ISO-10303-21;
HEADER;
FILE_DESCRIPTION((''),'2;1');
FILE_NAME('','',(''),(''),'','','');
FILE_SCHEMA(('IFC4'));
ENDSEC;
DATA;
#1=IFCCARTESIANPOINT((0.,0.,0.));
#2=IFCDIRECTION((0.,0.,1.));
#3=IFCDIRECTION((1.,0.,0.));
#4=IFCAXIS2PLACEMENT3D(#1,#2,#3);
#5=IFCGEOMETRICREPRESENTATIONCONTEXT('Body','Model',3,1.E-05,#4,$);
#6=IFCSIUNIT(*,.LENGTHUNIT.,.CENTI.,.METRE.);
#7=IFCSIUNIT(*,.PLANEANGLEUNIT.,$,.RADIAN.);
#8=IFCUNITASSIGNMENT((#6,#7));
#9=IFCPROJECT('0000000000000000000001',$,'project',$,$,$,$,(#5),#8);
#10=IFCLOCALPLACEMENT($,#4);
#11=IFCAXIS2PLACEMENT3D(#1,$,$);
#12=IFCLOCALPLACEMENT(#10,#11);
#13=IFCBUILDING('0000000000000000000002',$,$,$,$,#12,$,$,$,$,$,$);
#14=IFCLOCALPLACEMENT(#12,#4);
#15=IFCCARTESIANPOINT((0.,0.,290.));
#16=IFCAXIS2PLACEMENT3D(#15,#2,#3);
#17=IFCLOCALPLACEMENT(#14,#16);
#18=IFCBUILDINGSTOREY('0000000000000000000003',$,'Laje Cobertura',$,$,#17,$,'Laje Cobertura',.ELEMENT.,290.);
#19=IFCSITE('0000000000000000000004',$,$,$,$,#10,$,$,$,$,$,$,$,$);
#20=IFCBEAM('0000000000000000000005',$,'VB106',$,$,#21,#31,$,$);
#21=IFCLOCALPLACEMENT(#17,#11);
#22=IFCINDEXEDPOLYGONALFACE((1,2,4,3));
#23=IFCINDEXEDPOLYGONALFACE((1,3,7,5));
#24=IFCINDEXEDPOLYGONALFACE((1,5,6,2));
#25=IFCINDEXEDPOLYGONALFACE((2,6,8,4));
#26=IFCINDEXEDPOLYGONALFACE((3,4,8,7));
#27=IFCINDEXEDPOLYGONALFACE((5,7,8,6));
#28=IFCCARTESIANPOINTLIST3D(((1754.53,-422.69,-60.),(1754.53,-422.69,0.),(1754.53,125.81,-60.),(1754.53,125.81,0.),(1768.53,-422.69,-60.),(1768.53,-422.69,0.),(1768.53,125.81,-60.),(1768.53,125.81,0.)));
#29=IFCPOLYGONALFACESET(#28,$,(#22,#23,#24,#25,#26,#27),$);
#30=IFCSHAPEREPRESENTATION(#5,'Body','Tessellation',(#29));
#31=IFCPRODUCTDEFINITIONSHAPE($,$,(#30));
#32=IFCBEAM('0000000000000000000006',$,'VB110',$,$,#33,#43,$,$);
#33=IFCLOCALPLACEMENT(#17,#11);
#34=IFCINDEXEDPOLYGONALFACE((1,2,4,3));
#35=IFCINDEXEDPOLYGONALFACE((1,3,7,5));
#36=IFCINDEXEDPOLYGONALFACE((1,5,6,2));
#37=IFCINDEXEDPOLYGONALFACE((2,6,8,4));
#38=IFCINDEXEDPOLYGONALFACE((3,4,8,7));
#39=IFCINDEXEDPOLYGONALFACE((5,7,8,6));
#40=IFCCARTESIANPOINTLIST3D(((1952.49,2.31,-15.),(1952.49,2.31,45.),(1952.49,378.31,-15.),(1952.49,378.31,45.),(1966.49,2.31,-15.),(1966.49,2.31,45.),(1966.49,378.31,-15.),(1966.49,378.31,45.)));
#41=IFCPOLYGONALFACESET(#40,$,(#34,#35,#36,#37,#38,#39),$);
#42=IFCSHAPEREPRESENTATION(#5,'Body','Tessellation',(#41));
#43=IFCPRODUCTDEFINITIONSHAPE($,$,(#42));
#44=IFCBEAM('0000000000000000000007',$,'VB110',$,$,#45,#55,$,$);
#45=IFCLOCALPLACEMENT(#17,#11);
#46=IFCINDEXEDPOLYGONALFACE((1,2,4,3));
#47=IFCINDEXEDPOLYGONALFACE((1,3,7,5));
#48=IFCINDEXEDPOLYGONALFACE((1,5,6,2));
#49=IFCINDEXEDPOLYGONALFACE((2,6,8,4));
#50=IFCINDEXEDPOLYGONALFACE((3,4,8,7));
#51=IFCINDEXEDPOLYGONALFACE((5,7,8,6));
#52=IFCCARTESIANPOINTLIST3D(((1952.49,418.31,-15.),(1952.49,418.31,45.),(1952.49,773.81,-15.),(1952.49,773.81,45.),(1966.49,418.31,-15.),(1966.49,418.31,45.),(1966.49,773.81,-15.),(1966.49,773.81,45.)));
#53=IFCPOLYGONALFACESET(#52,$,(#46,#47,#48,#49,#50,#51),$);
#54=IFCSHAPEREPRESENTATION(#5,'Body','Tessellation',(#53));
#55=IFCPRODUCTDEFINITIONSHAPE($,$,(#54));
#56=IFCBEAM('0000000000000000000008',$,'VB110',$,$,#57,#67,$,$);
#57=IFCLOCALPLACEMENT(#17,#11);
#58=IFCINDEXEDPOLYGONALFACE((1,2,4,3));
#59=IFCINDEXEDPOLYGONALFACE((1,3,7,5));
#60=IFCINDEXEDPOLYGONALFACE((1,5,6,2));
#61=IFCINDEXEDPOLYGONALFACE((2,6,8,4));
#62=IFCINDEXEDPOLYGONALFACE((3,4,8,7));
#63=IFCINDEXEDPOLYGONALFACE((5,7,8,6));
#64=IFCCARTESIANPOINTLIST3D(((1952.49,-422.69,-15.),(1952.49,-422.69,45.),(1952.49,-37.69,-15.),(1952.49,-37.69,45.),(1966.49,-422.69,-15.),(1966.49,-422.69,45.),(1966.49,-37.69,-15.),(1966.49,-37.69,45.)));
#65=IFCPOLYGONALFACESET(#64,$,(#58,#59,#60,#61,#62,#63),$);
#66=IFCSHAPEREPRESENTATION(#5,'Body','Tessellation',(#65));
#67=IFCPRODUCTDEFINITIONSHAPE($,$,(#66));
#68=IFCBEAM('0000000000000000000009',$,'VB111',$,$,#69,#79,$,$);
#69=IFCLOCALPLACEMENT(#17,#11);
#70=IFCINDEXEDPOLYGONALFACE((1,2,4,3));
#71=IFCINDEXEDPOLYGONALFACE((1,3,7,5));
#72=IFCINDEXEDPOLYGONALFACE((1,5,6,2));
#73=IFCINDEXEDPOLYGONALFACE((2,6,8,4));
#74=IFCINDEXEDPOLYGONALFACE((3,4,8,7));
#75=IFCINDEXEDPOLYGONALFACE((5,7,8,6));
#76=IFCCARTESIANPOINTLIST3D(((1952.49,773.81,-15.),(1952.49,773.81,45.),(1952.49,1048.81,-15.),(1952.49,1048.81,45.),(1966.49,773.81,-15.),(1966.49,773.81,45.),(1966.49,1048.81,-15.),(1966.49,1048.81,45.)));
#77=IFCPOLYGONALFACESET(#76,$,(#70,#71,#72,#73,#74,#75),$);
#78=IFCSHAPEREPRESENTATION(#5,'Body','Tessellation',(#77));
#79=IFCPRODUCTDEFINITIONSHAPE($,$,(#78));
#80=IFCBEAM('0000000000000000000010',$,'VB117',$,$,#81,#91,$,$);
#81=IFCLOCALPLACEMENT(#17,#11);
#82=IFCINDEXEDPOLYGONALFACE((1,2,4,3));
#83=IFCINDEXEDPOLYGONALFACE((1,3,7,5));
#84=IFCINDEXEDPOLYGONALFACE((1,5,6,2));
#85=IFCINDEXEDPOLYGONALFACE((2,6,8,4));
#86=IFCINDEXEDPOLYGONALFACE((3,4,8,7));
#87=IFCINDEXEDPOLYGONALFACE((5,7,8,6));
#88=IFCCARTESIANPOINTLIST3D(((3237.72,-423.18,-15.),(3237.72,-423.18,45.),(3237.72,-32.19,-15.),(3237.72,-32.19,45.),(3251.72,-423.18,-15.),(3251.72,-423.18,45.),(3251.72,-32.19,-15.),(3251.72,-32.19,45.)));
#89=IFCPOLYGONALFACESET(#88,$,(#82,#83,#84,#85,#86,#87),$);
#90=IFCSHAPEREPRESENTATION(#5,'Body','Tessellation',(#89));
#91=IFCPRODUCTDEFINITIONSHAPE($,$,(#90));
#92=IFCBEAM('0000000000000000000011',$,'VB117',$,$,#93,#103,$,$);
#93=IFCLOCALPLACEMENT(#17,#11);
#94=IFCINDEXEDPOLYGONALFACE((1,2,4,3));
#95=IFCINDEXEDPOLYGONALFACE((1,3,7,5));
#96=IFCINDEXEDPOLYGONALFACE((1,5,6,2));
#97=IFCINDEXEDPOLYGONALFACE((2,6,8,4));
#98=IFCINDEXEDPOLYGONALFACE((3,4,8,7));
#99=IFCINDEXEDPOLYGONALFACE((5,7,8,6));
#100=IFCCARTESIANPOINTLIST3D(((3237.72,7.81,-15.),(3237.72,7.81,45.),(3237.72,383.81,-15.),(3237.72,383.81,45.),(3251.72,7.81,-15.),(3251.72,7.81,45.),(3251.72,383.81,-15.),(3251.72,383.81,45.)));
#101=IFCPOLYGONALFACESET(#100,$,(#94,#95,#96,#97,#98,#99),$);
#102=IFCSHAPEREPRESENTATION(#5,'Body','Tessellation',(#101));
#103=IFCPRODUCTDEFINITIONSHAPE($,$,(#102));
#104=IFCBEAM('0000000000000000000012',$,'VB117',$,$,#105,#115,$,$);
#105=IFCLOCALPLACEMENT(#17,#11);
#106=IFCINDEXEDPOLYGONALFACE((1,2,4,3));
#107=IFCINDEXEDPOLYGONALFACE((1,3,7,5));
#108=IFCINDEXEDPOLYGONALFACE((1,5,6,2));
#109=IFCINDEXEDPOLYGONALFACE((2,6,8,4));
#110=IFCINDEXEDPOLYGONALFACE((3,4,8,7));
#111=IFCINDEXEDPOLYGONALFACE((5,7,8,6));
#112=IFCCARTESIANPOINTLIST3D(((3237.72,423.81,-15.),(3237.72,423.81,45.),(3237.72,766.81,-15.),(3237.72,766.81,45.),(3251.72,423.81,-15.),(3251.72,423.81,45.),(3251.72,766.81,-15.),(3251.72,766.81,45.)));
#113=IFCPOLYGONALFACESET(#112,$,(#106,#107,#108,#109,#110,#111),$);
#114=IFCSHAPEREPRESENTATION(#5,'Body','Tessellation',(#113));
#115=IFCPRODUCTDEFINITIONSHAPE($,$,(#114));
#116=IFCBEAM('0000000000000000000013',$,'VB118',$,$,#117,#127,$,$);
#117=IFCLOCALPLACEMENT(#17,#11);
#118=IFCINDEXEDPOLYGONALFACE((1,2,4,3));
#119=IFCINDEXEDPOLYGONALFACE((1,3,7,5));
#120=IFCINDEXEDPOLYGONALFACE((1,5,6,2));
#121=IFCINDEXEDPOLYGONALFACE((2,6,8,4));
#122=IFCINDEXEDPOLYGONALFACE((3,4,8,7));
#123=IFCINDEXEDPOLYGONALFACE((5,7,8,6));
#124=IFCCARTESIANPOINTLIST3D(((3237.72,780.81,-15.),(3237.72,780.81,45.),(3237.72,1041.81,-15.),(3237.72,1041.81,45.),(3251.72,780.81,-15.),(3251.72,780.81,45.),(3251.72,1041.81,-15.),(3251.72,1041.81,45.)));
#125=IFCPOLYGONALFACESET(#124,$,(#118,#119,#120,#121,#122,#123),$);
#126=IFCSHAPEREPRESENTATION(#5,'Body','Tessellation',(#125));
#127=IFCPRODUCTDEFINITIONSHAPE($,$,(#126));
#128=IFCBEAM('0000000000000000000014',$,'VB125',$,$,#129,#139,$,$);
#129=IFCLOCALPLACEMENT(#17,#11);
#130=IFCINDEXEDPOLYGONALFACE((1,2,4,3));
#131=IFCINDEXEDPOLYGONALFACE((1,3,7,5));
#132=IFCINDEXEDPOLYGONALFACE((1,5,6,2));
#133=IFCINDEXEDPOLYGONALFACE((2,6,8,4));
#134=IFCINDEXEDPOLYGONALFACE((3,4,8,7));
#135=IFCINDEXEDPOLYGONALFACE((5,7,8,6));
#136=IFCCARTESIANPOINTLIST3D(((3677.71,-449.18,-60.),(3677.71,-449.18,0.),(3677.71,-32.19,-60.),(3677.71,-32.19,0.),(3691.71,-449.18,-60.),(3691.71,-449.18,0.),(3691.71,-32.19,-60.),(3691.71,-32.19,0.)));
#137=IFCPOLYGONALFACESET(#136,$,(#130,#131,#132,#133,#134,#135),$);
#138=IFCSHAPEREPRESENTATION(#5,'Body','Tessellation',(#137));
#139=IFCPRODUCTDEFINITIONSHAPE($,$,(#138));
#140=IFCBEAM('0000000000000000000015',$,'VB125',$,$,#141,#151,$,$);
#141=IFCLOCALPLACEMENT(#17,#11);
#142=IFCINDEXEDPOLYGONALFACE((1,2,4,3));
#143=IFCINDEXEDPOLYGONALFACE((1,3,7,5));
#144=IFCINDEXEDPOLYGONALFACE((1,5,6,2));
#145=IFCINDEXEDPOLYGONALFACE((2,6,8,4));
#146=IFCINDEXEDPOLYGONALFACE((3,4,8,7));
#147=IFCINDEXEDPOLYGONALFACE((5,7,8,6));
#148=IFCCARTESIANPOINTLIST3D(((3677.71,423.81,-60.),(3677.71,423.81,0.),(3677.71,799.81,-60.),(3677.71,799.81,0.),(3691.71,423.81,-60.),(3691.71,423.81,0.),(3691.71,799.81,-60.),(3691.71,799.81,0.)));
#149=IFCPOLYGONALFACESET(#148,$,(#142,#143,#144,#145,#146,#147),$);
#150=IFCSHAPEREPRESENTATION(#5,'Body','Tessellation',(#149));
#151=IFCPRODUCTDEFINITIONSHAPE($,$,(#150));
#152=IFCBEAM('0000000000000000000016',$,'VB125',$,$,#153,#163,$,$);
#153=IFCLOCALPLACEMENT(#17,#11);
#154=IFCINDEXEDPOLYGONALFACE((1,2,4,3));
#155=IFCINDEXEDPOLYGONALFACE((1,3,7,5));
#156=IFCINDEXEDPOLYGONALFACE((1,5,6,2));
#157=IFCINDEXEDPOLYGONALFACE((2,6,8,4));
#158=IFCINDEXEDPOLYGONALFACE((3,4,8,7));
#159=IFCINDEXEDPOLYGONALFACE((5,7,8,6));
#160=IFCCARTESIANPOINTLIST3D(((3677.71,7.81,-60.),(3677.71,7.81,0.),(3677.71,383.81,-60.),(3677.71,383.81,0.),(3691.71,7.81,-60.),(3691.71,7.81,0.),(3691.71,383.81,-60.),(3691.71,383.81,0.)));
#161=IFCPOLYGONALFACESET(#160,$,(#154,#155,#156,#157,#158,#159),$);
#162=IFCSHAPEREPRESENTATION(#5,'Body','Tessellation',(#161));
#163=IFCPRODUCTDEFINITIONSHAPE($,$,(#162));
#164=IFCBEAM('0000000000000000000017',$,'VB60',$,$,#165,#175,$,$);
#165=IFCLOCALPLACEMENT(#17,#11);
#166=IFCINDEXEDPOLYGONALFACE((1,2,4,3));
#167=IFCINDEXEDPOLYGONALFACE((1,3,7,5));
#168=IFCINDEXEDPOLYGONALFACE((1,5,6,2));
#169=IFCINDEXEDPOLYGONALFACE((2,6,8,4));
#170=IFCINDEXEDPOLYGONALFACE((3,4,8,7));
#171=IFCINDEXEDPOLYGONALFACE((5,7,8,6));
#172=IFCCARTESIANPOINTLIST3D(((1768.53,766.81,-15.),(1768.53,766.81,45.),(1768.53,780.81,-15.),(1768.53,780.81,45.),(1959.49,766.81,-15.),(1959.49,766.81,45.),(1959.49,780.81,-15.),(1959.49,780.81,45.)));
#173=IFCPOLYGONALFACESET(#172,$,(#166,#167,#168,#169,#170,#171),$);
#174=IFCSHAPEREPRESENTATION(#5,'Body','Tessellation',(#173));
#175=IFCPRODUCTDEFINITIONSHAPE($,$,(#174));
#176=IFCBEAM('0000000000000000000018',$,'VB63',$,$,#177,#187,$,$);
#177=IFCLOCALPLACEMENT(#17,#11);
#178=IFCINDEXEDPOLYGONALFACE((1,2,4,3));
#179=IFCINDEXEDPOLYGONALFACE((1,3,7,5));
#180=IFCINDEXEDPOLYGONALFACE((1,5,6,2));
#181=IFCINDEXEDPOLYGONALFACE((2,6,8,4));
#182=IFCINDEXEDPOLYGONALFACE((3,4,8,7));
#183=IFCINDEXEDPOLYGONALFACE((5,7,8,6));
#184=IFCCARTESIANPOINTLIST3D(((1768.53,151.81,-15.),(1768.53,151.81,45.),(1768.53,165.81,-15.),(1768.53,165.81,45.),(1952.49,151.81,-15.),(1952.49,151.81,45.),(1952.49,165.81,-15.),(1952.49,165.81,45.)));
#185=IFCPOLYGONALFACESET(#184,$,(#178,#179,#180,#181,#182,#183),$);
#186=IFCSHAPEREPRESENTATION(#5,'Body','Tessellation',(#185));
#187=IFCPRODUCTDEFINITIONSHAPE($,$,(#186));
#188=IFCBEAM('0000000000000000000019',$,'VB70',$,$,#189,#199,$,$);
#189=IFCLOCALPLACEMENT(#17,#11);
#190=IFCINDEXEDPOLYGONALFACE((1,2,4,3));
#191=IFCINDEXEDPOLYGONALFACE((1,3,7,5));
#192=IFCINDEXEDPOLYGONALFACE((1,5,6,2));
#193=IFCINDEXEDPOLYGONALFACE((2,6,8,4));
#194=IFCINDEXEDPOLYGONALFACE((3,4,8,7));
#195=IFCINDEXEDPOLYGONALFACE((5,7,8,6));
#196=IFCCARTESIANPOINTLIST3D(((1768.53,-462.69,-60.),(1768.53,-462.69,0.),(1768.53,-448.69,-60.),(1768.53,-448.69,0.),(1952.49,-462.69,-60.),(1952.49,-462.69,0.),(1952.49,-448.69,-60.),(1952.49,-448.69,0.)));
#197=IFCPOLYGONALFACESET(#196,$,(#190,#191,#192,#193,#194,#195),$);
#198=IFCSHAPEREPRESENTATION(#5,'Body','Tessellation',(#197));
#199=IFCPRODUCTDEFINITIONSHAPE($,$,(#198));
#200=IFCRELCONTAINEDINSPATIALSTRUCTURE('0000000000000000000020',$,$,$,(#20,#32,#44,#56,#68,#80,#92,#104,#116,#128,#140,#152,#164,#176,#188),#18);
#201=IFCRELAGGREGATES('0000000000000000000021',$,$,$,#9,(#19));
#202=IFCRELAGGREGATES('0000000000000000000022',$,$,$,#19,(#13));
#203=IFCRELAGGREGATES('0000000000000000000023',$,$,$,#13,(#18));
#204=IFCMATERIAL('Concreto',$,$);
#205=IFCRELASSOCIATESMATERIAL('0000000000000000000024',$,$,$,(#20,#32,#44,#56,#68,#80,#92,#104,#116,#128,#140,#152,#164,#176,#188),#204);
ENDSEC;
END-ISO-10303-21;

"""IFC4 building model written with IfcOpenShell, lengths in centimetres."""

from ifc_helpers import new_model, si_unit, frame, origin, origin_with_axes, origin_2d_with_axis, place, context, project, spatial, rectangle, extrude, material, element, save


model = new_model("IFC4")

# Units and contexts
model_context = context("Model", 3, precision=1e-05, world=origin_with_axes(), identifier="Body")
ifc_project = project(units=[si_unit("LENGTHUNIT", "METRE", prefix="CENTI"), si_unit("PLANEANGLEUNIT", "RADIAN")], contexts=[model_context])

# Site, building, storey
site_placement = place(None, origin_with_axes())
site = spatial("IfcSite", under=ifc_project, at=site_placement)
building_placement = place(site_placement, origin())
building = spatial("IfcBuilding", under=site, at=building_placement)
placement = place(building_placement, origin_with_axes())
storey_placement = place(placement, frame((0.0, 0.0, 290.0), z_axis=(0.0, 0.0, 1.0), x_axis=(1.0, 0.0, 0.0)))
storey = spatial("IfcBuildingStorey", under=building, at=storey_placement, Name="Laje Cobertura", LongName="Laje Cobertura", CompositionType="ELEMENT", Elevation=290.0)

# Shared definitions
ifc_material = material(Name="Concreto")

# Beams
beam_1_placement = place(storey_placement, frame((1761.53, -148.44, 0.0), z_axis=(0.0, 0.0, 1.0), x_axis=(1.0, 0.0, 0.0)))
element("IfcBeam", 1, at=beam_1_placement, inside=storey, material=ifc_material, Name="VB106", context=model_context, shape_type="SolidModel", body=[
    extrude(rectangle(XDim=14.0, YDim=60.0, at=origin_2d_with_axis()), frame((0.0, -274.25, -30.0), z_axis=(0.0, 1.0, 0.0), x_axis=(1.0, 0.0, 0.0)), (0.0, 0.0, 1.0), 548.5),
])
beam_2_placement = place(storey_placement, frame((1959.49, 190.31, 45.0), z_axis=(0.0, 0.0, 1.0), x_axis=(1.0, 0.0, 0.0)))
element("IfcBeam", 2, at=beam_2_placement, inside=storey, material=ifc_material, Name="VB110", context=model_context, shape_type="SolidModel", body=[
    extrude(rectangle(XDim=14.0, YDim=60.0, at=origin_2d_with_axis()), frame((0.0, -188.0, -30.0), z_axis=(0.0, 1.0, 0.0), x_axis=(1.0, 0.0, 0.0)), (0.0, 0.0, 1.0), 376.0),
])
beam_3_placement = place(storey_placement, frame((1959.49, 596.06, 45.0), z_axis=(0.0, 0.0, 1.0), x_axis=(1.0, 0.0, 0.0)))
element("IfcBeam", 3, at=beam_3_placement, inside=storey, material=ifc_material, Name="VB110", context=model_context, shape_type="SolidModel", body=[
    extrude(rectangle(XDim=14.0, YDim=60.0, at=origin_2d_with_axis()), frame((0.0, -177.75, -30.0), z_axis=(0.0, 1.0, 0.0), x_axis=(1.0, 0.0, 0.0)), (0.0, 0.0, 1.0), 355.5),
])
beam_4_placement = place(storey_placement, frame((1959.49, -230.19, 45.0), z_axis=(0.0, 0.0, 1.0), x_axis=(1.0, 0.0, 0.0)))
element("IfcBeam", 4, at=beam_4_placement, inside=storey, material=ifc_material, Name="VB110", context=model_context, shape_type="SolidModel", body=[
    extrude(rectangle(XDim=14.0, YDim=60.0, at=origin_2d_with_axis()), frame((0.0, -192.5, -30.0), z_axis=(0.0, 1.0, 0.0), x_axis=(1.0, 0.0, 0.0)), (0.0, 0.0, 1.0), 385.0),
])
beam_5_placement = place(storey_placement, frame((1959.49, 911.31, 45.0), z_axis=(0.0, 0.0, 1.0), x_axis=(1.0, 0.0, 0.0)))
element("IfcBeam", 5, at=beam_5_placement, inside=storey, material=ifc_material, Name="VB111", context=model_context, shape_type="SolidModel", body=[
    extrude(rectangle(XDim=14.0, YDim=60.0, at=origin_2d_with_axis()), frame((0.0, -137.5, -30.0), z_axis=(0.0, 1.0, 0.0), x_axis=(1.0, 0.0, 0.0)), (0.0, 0.0, 1.0), 275.0),
])
beam_6_placement = place(storey_placement, frame((3244.72, -227.69, 45.0), z_axis=(0.0, 0.0, 1.0), x_axis=(1.0, 0.0, 0.0)))
element("IfcBeam", 6, at=beam_6_placement, inside=storey, material=ifc_material, Name="VB117", context=model_context, shape_type="SolidModel", body=[
    extrude(rectangle(XDim=14.0, YDim=60.0, at=origin_2d_with_axis()), frame((0.0, -195.5, -30.0), z_axis=(0.0, 1.0, 0.0), x_axis=(1.0, 0.0, 0.0)), (0.0, 0.0, 1.0), 390.99),
])
beam_7_placement = place(storey_placement, frame((3244.72, 195.81, 45.0), z_axis=(0.0, 0.0, 1.0), x_axis=(1.0, 0.0, 0.0)))
element("IfcBeam", 7, at=beam_7_placement, inside=storey, material=ifc_material, Name="VB117", context=model_context, shape_type="SolidModel", body=[
    extrude(rectangle(XDim=14.0, YDim=60.0, at=origin_2d_with_axis()), frame((0.0, -188.0, -30.0), z_axis=(0.0, 1.0, 0.0), x_axis=(1.0, 0.0, 0.0)), (0.0, 0.0, 1.0), 376.0),
])
beam_8_placement = place(storey_placement, frame((3244.72, 595.31, 45.0), z_axis=(0.0, 0.0, 1.0), x_axis=(1.0, 0.0, 0.0)))
element("IfcBeam", 8, at=beam_8_placement, inside=storey, material=ifc_material, Name="VB117", context=model_context, shape_type="SolidModel", body=[
    extrude(rectangle(XDim=14.0, YDim=60.0, at=origin_2d_with_axis()), frame((0.0, -171.5, -30.0), z_axis=(0.0, 1.0, 0.0), x_axis=(1.0, 0.0, 0.0)), (0.0, 0.0, 1.0), 343.0),
])
beam_9_placement = place(storey_placement, frame((3244.72, 911.31, 45.0), z_axis=(0.0, 0.0, 1.0), x_axis=(1.0, 0.0, 0.0)))
element("IfcBeam", 9, at=beam_9_placement, inside=storey, material=ifc_material, Name="VB118", context=model_context, shape_type="SolidModel", body=[
    extrude(rectangle(XDim=14.0, YDim=60.0, at=origin_2d_with_axis()), frame((0.0, -130.5, -30.0), z_axis=(0.0, 1.0, 0.0), x_axis=(1.0, 0.0, 0.0)), (0.0, 0.0, 1.0), 261.0),
])
beam_10_placement = place(storey_placement, frame((3684.71, -240.69, 0.0), z_axis=(0.0, 0.0, 1.0), x_axis=(1.0, 0.0, 0.0)))
element("IfcBeam", 10, at=beam_10_placement, inside=storey, material=ifc_material, Name="VB125", context=model_context, shape_type="SolidModel", body=[
    extrude(rectangle(XDim=14.0, YDim=60.0, at=origin_2d_with_axis()), frame((0.0, -208.5, -30.0), z_axis=(0.0, 1.0, 0.0), x_axis=(1.0, 0.0, 0.0)), (0.0, 0.0, 1.0), 416.99),
])
for number, where, z_axis, x_axis, name in (
    (11, (3684.71, 611.81, 0.0), (0.0, 0.0, 1.0), (1.0, 0.0, 0.0), "VB125"),
    (12, (3684.71, 195.81, 0.0), (0.0, 0.0, 1.0), (1.0, 0.0, 0.0), "VB125"),
):
    element("IfcBeam", number, at=place(storey_placement, frame(where, z_axis=z_axis, x_axis=x_axis)), inside=storey, material=ifc_material, Name=name, context=model_context, shape_type="SolidModel", body=[
        extrude(rectangle(XDim=14.0, YDim=60.0, at=origin_2d_with_axis()), frame((0.0, -188.0, -30.0), z_axis=(0.0, 1.0, 0.0), x_axis=(1.0, 0.0, 0.0)), (0.0, 0.0, 1.0), 376.0),
    ])
beam_11_placement = place(storey_placement, frame((1864.01, 773.81, 45.0), z_axis=(0.0, 0.0, 1.0), x_axis=(1.0, 0.0, 0.0)))
element("IfcBeam", 13, at=beam_11_placement, inside=storey, material=ifc_material, Name="VB60", context=model_context, shape_type="SolidModel", body=[
    extrude(rectangle(XDim=14.0, YDim=60.0, at=origin_2d_with_axis()), frame((-95.48, 0.0, -30.0), z_axis=(1.0, 0.0, 0.0), x_axis=(0.0, 1.0, 0.0)), (0.0, 0.0, 1.0), 190.96),
])
for number, where, z_axis, x_axis, name in (
    (14, (1860.51, 158.81, 45.0), (0.0, 0.0, 1.0), (1.0, 0.0, 0.0), "VB63"),
    (15, (1860.51, -455.69, 0.0), (0.0, 0.0, 1.0), (1.0, 0.0, 0.0), "VB70"),
):
    element("IfcBeam", number, at=place(storey_placement, frame(where, z_axis=z_axis, x_axis=x_axis)), inside=storey, material=ifc_material, Name=name, context=model_context, shape_type="SolidModel", body=[
        extrude(rectangle(XDim=14.0, YDim=60.0, at=origin_2d_with_axis()), frame((-91.98, 0.0, -30.0), z_axis=(1.0, 0.0, 0.0), x_axis=(0.0, 1.0, 0.0)), (0.0, 0.0, 1.0), 183.96),
    ])

save(model, "model.ifc")
